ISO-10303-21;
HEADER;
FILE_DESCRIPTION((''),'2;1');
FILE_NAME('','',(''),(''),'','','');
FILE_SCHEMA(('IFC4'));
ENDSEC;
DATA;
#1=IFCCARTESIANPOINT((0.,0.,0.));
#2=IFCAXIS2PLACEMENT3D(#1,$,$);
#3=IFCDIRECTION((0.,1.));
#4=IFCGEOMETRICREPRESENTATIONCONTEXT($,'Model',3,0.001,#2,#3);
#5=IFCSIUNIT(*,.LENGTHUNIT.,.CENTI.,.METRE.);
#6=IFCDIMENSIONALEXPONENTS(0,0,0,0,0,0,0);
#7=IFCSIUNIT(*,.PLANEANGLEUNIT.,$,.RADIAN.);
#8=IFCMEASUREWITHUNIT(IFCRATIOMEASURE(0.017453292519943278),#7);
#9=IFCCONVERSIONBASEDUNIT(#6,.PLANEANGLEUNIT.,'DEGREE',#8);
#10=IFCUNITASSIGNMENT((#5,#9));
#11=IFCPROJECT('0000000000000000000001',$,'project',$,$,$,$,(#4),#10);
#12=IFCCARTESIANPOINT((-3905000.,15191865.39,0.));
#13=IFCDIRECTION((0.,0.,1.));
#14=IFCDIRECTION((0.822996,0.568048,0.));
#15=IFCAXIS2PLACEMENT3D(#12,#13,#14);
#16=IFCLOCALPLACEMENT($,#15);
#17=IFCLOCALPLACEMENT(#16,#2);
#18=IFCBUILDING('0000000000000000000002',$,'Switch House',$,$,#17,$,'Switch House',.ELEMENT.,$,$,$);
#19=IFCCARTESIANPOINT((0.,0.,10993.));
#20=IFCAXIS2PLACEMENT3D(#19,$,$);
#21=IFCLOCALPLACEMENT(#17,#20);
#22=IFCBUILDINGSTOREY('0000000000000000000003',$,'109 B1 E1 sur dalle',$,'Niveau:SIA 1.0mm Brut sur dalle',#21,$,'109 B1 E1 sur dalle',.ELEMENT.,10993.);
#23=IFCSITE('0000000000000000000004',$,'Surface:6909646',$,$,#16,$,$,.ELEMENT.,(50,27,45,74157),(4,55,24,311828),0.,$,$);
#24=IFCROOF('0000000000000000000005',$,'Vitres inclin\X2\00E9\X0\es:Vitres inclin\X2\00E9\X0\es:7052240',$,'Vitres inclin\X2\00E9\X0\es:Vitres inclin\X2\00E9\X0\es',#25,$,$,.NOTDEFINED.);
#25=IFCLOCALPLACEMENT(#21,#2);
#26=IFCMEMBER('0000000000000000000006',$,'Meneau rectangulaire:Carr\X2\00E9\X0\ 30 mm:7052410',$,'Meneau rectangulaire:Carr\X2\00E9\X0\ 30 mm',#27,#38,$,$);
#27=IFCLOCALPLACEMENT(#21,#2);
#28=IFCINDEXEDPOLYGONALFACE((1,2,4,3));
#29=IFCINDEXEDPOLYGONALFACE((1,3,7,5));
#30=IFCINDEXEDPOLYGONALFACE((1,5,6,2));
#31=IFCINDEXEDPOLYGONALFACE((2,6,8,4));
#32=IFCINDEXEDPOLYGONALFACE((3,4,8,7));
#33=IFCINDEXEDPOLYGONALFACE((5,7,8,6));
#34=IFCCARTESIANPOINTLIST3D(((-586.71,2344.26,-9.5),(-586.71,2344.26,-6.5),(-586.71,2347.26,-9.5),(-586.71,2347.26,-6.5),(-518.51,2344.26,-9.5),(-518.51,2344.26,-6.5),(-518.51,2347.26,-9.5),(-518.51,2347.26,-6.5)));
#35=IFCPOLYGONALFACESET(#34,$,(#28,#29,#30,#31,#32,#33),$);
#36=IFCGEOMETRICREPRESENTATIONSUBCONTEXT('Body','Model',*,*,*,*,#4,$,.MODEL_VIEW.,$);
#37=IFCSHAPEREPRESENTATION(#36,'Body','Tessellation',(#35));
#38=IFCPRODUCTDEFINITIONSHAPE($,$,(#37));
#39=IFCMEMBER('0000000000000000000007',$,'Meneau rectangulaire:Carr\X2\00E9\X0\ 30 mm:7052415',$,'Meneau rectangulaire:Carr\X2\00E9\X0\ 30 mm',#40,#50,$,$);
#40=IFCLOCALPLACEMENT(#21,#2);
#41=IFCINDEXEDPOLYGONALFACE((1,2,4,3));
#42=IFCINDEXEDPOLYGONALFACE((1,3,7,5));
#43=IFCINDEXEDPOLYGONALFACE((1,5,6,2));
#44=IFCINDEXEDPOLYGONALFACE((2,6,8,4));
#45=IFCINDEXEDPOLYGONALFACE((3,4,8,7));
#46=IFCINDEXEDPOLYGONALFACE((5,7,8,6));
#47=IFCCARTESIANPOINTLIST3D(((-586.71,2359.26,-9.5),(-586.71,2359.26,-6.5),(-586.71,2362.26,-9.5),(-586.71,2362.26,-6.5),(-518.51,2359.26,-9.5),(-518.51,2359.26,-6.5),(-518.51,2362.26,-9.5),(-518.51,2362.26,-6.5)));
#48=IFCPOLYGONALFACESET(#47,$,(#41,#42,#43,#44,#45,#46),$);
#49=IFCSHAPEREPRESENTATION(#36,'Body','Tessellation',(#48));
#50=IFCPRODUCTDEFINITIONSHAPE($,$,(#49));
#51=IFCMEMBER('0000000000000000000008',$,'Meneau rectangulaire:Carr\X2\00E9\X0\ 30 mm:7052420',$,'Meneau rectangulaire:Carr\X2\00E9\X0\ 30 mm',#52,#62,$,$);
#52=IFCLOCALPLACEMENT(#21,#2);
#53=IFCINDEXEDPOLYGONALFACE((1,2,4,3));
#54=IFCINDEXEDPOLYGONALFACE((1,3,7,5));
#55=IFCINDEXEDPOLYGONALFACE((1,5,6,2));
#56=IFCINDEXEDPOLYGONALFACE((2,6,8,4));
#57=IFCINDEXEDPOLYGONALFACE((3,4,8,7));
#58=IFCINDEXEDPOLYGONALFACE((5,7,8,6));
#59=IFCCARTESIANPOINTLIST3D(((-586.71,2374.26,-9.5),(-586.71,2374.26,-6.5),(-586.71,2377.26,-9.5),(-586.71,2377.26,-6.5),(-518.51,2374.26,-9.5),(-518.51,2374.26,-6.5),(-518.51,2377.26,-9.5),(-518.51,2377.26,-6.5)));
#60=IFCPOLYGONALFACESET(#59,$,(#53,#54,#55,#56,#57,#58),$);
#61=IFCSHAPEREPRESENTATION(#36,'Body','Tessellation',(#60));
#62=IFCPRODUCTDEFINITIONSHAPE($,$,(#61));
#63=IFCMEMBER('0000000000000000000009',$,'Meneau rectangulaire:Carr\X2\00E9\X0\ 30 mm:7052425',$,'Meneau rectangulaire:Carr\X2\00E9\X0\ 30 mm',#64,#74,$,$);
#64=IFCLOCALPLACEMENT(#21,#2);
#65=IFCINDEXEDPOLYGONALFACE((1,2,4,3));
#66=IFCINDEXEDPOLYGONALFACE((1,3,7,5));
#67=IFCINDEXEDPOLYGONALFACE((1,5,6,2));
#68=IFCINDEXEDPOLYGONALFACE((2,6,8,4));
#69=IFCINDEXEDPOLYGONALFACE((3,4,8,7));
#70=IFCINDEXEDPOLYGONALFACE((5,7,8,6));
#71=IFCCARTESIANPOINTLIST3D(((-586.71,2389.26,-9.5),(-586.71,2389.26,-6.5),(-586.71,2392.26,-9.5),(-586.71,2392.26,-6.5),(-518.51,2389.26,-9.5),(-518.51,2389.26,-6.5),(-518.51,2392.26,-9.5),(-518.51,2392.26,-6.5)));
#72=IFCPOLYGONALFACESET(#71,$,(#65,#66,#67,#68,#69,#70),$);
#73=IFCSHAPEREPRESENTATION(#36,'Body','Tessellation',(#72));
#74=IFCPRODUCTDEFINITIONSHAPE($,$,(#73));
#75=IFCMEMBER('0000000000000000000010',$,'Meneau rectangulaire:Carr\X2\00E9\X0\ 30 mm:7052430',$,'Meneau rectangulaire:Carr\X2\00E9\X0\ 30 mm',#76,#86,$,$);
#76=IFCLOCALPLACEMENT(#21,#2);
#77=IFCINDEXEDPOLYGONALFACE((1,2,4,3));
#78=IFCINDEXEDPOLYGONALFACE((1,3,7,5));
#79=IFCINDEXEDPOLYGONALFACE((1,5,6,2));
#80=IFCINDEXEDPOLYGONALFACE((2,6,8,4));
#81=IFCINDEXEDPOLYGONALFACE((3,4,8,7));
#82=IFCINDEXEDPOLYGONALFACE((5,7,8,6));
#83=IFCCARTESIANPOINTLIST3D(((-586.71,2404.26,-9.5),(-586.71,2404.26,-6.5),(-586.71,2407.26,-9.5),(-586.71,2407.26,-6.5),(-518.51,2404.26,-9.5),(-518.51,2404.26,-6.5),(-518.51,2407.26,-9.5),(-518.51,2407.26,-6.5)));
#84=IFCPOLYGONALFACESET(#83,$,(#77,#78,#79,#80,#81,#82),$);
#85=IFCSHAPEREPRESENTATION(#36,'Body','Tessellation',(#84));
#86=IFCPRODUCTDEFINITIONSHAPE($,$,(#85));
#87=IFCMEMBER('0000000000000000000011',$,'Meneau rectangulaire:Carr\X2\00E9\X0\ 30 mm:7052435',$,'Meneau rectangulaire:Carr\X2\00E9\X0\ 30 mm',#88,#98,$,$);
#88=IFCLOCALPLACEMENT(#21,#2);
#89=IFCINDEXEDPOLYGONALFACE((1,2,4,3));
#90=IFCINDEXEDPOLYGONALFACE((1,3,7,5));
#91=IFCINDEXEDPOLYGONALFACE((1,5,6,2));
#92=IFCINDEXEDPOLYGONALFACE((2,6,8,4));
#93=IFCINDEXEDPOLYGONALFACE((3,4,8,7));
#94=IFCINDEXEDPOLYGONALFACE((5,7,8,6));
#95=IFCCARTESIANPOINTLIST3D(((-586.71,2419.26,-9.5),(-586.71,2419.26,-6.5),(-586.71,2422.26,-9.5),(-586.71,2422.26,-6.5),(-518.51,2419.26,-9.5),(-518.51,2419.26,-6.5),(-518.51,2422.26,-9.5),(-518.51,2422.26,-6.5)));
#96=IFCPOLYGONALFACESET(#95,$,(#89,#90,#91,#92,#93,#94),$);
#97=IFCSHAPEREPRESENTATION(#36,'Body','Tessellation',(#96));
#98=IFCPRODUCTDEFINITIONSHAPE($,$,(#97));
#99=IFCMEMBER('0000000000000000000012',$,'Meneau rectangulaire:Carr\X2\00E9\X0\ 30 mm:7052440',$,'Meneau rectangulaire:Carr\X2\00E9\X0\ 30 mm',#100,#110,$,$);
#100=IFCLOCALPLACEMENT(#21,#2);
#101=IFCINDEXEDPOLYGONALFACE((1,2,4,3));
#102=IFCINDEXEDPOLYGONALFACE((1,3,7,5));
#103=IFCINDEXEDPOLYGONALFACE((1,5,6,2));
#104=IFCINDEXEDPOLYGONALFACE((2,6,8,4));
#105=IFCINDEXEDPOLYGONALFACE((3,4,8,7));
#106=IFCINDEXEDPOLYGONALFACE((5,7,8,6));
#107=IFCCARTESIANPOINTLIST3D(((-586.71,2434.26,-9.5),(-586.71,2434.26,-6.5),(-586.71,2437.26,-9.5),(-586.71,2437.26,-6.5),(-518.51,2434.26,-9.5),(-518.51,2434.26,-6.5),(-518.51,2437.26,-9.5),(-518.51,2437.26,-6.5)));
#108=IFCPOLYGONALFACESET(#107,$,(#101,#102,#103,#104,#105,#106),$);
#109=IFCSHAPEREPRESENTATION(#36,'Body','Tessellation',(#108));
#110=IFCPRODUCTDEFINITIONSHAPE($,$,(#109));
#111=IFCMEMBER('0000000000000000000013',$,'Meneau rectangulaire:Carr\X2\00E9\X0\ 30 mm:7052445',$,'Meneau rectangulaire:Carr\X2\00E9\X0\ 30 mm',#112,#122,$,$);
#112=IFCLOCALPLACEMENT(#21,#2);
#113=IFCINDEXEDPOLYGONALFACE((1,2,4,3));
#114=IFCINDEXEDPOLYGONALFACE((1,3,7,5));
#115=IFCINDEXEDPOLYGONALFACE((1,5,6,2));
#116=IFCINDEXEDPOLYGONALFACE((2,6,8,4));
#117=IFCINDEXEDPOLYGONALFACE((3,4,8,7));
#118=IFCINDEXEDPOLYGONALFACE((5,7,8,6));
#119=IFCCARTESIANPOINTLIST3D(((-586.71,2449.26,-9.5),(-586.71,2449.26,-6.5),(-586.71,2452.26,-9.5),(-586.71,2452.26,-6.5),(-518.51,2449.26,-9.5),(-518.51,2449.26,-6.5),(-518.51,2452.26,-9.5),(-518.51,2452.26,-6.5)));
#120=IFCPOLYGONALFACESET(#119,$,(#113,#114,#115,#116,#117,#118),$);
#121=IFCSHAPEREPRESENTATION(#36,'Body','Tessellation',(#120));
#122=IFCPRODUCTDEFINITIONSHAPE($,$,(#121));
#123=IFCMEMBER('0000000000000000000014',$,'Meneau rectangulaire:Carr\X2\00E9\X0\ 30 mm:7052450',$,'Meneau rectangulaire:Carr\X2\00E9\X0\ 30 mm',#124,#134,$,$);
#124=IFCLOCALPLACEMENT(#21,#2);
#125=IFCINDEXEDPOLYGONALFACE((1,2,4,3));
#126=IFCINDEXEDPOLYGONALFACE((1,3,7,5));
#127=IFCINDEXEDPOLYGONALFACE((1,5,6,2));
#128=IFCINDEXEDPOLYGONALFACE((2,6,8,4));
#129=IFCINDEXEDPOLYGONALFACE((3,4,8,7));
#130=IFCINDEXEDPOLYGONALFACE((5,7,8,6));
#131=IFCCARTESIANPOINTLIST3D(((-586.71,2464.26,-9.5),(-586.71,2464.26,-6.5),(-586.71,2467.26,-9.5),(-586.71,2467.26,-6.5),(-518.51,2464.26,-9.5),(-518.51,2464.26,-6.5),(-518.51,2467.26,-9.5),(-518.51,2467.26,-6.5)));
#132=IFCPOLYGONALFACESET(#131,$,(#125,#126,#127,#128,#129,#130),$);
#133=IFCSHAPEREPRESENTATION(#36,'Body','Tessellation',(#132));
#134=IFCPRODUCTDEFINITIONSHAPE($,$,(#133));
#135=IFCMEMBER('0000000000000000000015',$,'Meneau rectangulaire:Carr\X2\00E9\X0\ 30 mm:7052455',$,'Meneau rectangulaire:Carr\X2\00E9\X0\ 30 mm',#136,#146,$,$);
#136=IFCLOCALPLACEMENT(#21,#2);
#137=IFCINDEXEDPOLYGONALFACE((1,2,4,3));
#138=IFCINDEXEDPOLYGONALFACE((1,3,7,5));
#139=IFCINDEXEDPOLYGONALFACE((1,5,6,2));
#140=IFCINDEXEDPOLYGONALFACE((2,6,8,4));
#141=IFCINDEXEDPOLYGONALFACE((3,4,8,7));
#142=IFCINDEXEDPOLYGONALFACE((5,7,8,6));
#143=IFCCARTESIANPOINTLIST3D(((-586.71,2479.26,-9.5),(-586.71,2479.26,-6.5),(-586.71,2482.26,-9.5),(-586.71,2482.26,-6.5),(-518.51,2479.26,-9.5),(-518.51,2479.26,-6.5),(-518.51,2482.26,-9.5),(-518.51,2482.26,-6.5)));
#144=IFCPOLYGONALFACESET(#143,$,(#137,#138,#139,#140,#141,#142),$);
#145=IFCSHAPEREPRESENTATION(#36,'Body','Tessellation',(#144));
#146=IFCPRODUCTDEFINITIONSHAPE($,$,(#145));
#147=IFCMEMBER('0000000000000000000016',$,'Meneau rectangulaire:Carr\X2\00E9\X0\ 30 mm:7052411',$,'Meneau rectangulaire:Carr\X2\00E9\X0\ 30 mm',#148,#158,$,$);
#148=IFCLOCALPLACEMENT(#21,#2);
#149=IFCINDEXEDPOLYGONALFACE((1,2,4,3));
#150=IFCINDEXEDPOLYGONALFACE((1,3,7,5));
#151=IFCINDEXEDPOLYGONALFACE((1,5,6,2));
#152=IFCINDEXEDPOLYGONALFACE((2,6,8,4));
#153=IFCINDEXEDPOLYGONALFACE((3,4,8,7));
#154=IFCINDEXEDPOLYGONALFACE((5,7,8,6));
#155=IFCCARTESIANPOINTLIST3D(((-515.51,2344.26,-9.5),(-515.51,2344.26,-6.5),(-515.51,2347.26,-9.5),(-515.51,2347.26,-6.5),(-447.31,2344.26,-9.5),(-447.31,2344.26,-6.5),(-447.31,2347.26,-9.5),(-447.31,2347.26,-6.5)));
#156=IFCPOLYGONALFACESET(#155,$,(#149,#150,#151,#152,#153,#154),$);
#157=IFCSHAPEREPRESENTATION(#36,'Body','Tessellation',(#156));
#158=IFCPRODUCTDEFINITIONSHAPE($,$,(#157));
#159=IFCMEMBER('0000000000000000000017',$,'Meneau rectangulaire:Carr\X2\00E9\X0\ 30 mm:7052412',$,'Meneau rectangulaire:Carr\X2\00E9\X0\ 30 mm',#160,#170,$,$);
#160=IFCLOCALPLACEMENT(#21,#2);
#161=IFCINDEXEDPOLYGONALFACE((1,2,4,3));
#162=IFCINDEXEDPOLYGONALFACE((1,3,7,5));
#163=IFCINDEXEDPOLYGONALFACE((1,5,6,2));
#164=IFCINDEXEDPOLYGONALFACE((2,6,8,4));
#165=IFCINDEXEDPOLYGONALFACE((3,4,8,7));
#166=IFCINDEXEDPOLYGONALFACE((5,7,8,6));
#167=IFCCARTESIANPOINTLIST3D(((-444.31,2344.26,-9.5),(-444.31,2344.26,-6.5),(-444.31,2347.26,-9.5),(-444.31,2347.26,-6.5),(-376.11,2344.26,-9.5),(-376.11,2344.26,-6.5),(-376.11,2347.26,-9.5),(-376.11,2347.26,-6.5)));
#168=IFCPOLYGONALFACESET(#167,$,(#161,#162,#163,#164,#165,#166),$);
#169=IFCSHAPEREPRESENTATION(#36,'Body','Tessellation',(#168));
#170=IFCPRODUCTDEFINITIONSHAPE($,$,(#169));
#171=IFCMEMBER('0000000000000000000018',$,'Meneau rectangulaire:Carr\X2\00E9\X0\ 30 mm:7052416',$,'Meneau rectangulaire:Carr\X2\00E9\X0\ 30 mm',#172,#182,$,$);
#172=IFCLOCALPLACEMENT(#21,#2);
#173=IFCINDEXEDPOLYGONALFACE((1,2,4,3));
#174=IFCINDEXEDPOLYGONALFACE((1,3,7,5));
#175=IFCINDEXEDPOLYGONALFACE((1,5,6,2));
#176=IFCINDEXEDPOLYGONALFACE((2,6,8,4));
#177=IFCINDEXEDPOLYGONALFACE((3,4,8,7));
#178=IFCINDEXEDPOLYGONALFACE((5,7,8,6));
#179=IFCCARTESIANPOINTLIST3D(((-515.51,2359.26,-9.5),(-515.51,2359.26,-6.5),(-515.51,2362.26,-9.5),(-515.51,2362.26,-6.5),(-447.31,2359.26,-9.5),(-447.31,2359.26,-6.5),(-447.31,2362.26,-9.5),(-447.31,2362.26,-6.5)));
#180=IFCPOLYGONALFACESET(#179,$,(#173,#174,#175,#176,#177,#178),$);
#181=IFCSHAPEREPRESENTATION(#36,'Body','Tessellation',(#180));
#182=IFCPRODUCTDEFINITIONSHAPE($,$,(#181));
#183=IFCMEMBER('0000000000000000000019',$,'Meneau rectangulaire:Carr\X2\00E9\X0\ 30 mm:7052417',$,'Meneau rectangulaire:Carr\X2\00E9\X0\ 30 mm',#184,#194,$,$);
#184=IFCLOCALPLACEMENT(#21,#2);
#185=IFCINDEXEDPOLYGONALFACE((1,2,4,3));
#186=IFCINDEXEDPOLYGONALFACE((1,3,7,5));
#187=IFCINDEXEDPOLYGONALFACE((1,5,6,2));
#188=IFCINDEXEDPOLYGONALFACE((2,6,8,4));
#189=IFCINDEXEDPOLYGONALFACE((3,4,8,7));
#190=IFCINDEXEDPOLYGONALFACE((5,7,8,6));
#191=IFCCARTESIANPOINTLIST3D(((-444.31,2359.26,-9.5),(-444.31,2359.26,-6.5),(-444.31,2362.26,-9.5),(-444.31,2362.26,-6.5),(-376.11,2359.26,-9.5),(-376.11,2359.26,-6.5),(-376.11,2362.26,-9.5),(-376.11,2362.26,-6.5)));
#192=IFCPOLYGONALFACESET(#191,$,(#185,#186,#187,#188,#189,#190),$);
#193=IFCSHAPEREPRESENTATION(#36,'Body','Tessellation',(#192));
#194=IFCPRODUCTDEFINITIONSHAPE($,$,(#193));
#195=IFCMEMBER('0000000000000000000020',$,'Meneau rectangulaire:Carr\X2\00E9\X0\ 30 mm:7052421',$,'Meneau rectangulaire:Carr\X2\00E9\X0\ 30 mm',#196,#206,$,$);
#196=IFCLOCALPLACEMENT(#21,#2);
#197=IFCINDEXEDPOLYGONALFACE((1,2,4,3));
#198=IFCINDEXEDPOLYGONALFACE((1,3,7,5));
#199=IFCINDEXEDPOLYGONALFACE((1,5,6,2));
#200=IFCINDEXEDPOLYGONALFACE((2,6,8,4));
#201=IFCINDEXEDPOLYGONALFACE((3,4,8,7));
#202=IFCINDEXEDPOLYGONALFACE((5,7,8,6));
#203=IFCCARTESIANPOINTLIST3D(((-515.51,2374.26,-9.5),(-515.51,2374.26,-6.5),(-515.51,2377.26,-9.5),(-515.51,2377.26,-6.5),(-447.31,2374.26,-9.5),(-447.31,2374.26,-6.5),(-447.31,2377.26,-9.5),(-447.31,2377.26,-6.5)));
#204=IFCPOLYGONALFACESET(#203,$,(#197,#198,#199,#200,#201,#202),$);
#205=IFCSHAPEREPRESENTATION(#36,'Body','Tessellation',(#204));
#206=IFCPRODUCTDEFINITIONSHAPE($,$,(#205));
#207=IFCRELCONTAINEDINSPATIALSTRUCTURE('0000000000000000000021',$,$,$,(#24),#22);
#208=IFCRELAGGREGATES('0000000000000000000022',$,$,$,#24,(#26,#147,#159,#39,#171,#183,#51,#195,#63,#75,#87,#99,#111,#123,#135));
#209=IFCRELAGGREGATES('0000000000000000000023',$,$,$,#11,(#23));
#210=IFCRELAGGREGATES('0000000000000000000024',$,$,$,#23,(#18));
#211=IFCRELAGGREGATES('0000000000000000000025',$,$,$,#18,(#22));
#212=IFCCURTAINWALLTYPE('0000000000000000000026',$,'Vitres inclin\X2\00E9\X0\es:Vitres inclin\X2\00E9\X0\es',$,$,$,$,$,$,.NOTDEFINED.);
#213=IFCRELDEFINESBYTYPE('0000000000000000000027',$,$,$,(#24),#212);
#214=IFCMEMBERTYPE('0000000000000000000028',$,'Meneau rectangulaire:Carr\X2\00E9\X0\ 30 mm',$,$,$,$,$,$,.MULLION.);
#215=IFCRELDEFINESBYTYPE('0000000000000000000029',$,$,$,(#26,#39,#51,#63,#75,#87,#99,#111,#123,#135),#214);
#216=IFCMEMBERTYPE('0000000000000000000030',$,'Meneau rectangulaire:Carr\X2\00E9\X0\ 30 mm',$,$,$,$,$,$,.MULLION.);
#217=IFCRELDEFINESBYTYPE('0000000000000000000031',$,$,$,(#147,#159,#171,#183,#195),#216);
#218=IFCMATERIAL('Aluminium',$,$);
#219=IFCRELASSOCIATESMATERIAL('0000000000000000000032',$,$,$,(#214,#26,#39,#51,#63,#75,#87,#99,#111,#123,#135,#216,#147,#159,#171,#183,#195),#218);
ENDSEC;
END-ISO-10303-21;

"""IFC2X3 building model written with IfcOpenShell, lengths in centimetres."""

from ifc_helpers import new_model, entity, si_unit, converted_unit, direction, frame, origin, origin_2d_with_axis, place, context, subcontext, project, spatial, rectangle, extrude, source, transform, mapped, material, type_object, type_shapes, element, aggregate, save


model = new_model("IFC2X3")

# Units and contexts
model_context = context("Model", 3, precision=0.001, world=origin(), true_north=direction((0.0, 1.0)))
body_context = subcontext(model_context, "Body", "Model", "MODEL_VIEW")
ifc_project = project(units=[si_unit("LENGTHUNIT", "METRE", prefix="CENTI"), converted_unit("PLANEANGLEUNIT", "DEGREE", entity("IfcRatioMeasure", 0.017453292519943278), si_unit("PLANEANGLEUNIT", "RADIAN"), dimensions=[0, 0, 0, 0, 0, 0, 0])], contexts=[model_context])

# Site, building, storey
site_placement = place(None, frame((-3905000.0, 15191865.39, 0.0), z_axis=(0.0, 0.0, 1.0), x_axis=(0.822996, 0.568048, 0.0)))
site = spatial("IfcSite", under=ifc_project, at=site_placement, Name="Surface:6909646", CompositionType="ELEMENT", RefLatitude=(50, 27, 45, 74157), RefLongitude=(4, 55, 24, 311828), RefElevation=0.0)
building_placement = place(site_placement, origin())
building = spatial("IfcBuilding", under=site, at=building_placement, Name="Switch House", LongName="Switch House", CompositionType="ELEMENT")
storey_placement = place(building_placement, frame((0.0, 0.0, 10993.0)))
storey = spatial("IfcBuildingStorey", under=building, at=storey_placement, Name="109 B1 E1 sur dalle", ObjectType="Niveau:SIA 1.0mm Brut sur dalle", LongName="109 B1 E1 sur dalle", CompositionType="ELEMENT", Elevation=10993.0)

# Roof, members
curtain_wall_type = type_object("IfcCurtainWallType", Name="Vitres inclinées:Vitres inclinées", PredefinedType="NOTDEFINED")
roof_1_placement = place(storey_placement, frame((0.0, 0.0, -10993.0)))
roof_1 = element("IfcRoof", 1, at=roof_1_placement, inside=storey, type_object=curtain_wall_type, Name="Vitres inclinées:Vitres inclinées:7052240", ObjectType="Vitres inclinées:Vitres inclinées", ShapeType="NOTDEFINED")
ifc_material_1 = material(Name="Aluminium")
member_type_1 = type_object("IfcMemberType", Name="Meneau rectangulaire:Carré 30 mm", PredefinedType="MULLION", material=ifc_material_1)
shared_shape_1 = source(origin(), body_context, "Body", "SweptSolid", [
    extrude(rectangle(XDim=3.0, YDim=3.0, at=origin_2d_with_axis()), frame((0.0, 0.0, -68.2), z_axis=(0.0, 0.0, 1.0), x_axis=(0.0, -1.0, 0.0)), (0.0, 0.0, 1.0), 68.2),
])
type_shapes(member_type_1, [shared_shape_1])
member_1_placement = place(roof_1_placement, frame((-586.71, 2345.76, 10985.0), z_axis=(-1.0, 0.0, 0.0), x_axis=(0.0, 1.0, 0.0)))
member_1 = element("IfcMember", 2, at=member_1_placement, type_object=member_type_1, material=ifc_material_1, Name="Meneau rectangulaire:Carré 30 mm:7052410", ObjectType="Meneau rectangulaire:Carré 30 mm", context=body_context, shape_type="MappedRepresentation", body=[
    mapped(shared_shape_1, transform((0.0, 0.0, 0.0), scale=1.0)),
])
member_2_placement = place(roof_1_placement, frame((-586.71, 2360.76, 10985.0), z_axis=(-1.0, 0.0, 0.0), x_axis=(0.0, 1.0, 0.0)))
member_2 = element("IfcMember", 3, at=member_2_placement, type_object=member_type_1, material=ifc_material_1, Name="Meneau rectangulaire:Carré 30 mm:7052415", ObjectType="Meneau rectangulaire:Carré 30 mm", context=body_context, shape_type="MappedRepresentation", body=[
    mapped(shared_shape_1, transform((0.0, 0.0, 0.0), scale=1.0)),
])
member_3_placement = place(roof_1_placement, frame((-586.71, 2375.76, 10985.0), z_axis=(-1.0, 0.0, 0.0), x_axis=(0.0, 1.0, 0.0)))
member_3 = element("IfcMember", 4, at=member_3_placement, type_object=member_type_1, material=ifc_material_1, Name="Meneau rectangulaire:Carré 30 mm:7052420", ObjectType="Meneau rectangulaire:Carré 30 mm", context=body_context, shape_type="MappedRepresentation", body=[
    mapped(shared_shape_1, transform((0.0, 0.0, 0.0), scale=1.0)),
])
member_4_placement = place(roof_1_placement, frame((-586.71, 2390.76, 10985.0), z_axis=(-1.0, 0.0, 0.0), x_axis=(0.0, 1.0, 0.0)))
member_4 = element("IfcMember", 5, at=member_4_placement, type_object=member_type_1, material=ifc_material_1, Name="Meneau rectangulaire:Carré 30 mm:7052425", ObjectType="Meneau rectangulaire:Carré 30 mm", context=body_context, shape_type="MappedRepresentation", body=[
    mapped(shared_shape_1, transform((0.0, 0.0, 0.0), scale=1.0)),
])
member_5_placement = place(roof_1_placement, frame((-586.71, 2405.76, 10985.0), z_axis=(-1.0, 0.0, 0.0), x_axis=(0.0, 1.0, 0.0)))
member_5 = element("IfcMember", 6, at=member_5_placement, type_object=member_type_1, material=ifc_material_1, Name="Meneau rectangulaire:Carré 30 mm:7052430", ObjectType="Meneau rectangulaire:Carré 30 mm", context=body_context, shape_type="MappedRepresentation", body=[
    mapped(shared_shape_1, transform((0.0, 0.0, 0.0), scale=1.0)),
])
member_6_placement = place(roof_1_placement, frame((-586.71, 2420.76, 10985.0), z_axis=(-1.0, 0.0, 0.0), x_axis=(0.0, 1.0, 0.0)))
member_6 = element("IfcMember", 7, at=member_6_placement, type_object=member_type_1, material=ifc_material_1, Name="Meneau rectangulaire:Carré 30 mm:7052435", ObjectType="Meneau rectangulaire:Carré 30 mm", context=body_context, shape_type="MappedRepresentation", body=[
    mapped(shared_shape_1, transform((0.0, 0.0, 0.0), scale=1.0)),
])
member_7_placement = place(roof_1_placement, frame((-586.71, 2435.76, 10985.0), z_axis=(-1.0, 0.0, 0.0), x_axis=(0.0, 1.0, 0.0)))
member_7 = element("IfcMember", 8, at=member_7_placement, type_object=member_type_1, material=ifc_material_1, Name="Meneau rectangulaire:Carré 30 mm:7052440", ObjectType="Meneau rectangulaire:Carré 30 mm", context=body_context, shape_type="MappedRepresentation", body=[
    mapped(shared_shape_1, transform((0.0, 0.0, 0.0), scale=1.0)),
])
member_8_placement = place(roof_1_placement, frame((-586.71, 2450.76, 10985.0), z_axis=(-1.0, 0.0, 0.0), x_axis=(0.0, 1.0, 0.0)))
member_8 = element("IfcMember", 9, at=member_8_placement, type_object=member_type_1, material=ifc_material_1, Name="Meneau rectangulaire:Carré 30 mm:7052445", ObjectType="Meneau rectangulaire:Carré 30 mm", context=body_context, shape_type="MappedRepresentation", body=[
    mapped(shared_shape_1, transform((0.0, 0.0, 0.0), scale=1.0)),
])
member_9_placement = place(roof_1_placement, frame((-586.71, 2465.76, 10985.0), z_axis=(-1.0, 0.0, 0.0), x_axis=(0.0, 1.0, 0.0)))
member_9 = element("IfcMember", 10, at=member_9_placement, type_object=member_type_1, material=ifc_material_1, Name="Meneau rectangulaire:Carré 30 mm:7052450", ObjectType="Meneau rectangulaire:Carré 30 mm", context=body_context, shape_type="MappedRepresentation", body=[
    mapped(shared_shape_1, transform((0.0, 0.0, 0.0), scale=1.0)),
])
member_10_placement = place(roof_1_placement, frame((-586.71, 2480.76, 10985.0), z_axis=(-1.0, 0.0, 0.0), x_axis=(0.0, 1.0, 0.0)))
member_10 = element("IfcMember", 11, at=member_10_placement, type_object=member_type_1, material=ifc_material_1, Name="Meneau rectangulaire:Carré 30 mm:7052455", ObjectType="Meneau rectangulaire:Carré 30 mm", context=body_context, shape_type="MappedRepresentation", body=[
    mapped(shared_shape_1, transform((0.0, 0.0, 0.0), scale=1.0)),
])
member_type_2 = type_object("IfcMemberType", Name="Meneau rectangulaire:Carré 30 mm", PredefinedType="MULLION", material=ifc_material_1)
shared_shape_2 = source(origin(), body_context, "Body", "SweptSolid", [
    extrude(rectangle(XDim=3.0, YDim=3.0, at=origin_2d_with_axis()), frame((0.0, 0.0, -68.2), z_axis=(0.0, 0.0, 1.0), x_axis=(0.0, -1.0, 0.0)), (0.0, 0.0, 1.0), 68.2),
])
type_shapes(member_type_2, [shared_shape_2])
member_11_placement = place(roof_1_placement, frame((-515.51, 2345.76, 10985.0), z_axis=(-1.0, 0.0, 0.0), x_axis=(0.0, 1.0, 0.0)))
member_11 = element("IfcMember", 12, at=member_11_placement, type_object=member_type_2, material=ifc_material_1, Name="Meneau rectangulaire:Carré 30 mm:7052411", ObjectType="Meneau rectangulaire:Carré 30 mm", context=body_context, shape_type="MappedRepresentation", body=[
    mapped(shared_shape_2, transform((0.0, 0.0, 0.0), scale=1.0)),
])
member_12_placement = place(roof_1_placement, frame((-444.31, 2345.76, 10985.0), z_axis=(-1.0, 0.0, 0.0), x_axis=(0.0, 1.0, 0.0)))
member_12 = element("IfcMember", 13, at=member_12_placement, type_object=member_type_2, material=ifc_material_1, Name="Meneau rectangulaire:Carré 30 mm:7052412", ObjectType="Meneau rectangulaire:Carré 30 mm", context=body_context, shape_type="MappedRepresentation", body=[
    mapped(shared_shape_2, transform((0.0, 0.0, 0.0), scale=1.0)),
])
member_13_placement = place(roof_1_placement, frame((-515.51, 2360.76, 10985.0), z_axis=(-1.0, 0.0, 0.0), x_axis=(0.0, 1.0, 0.0)))
member_13 = element("IfcMember", 14, at=member_13_placement, type_object=member_type_2, material=ifc_material_1, Name="Meneau rectangulaire:Carré 30 mm:7052416", ObjectType="Meneau rectangulaire:Carré 30 mm", context=body_context, shape_type="MappedRepresentation", body=[
    mapped(shared_shape_2, transform((0.0, 0.0, 0.0), scale=1.0)),
])
member_14_placement = place(roof_1_placement, frame((-444.31, 2360.76, 10985.0), z_axis=(-1.0, 0.0, 0.0), x_axis=(0.0, 1.0, 0.0)))
member_14 = element("IfcMember", 15, at=member_14_placement, type_object=member_type_2, material=ifc_material_1, Name="Meneau rectangulaire:Carré 30 mm:7052417", ObjectType="Meneau rectangulaire:Carré 30 mm", context=body_context, shape_type="MappedRepresentation", body=[
    mapped(shared_shape_2, transform((0.0, 0.0, 0.0), scale=1.0)),
])
member_15_placement = place(roof_1_placement, frame((-515.51, 2375.76, 10985.0), z_axis=(-1.0, 0.0, 0.0), x_axis=(0.0, 1.0, 0.0)))
member_15 = element("IfcMember", 16, at=member_15_placement, type_object=member_type_2, material=ifc_material_1, Name="Meneau rectangulaire:Carré 30 mm:7052421", ObjectType="Meneau rectangulaire:Carré 30 mm", context=body_context, shape_type="MappedRepresentation", body=[
    mapped(shared_shape_2, transform((0.0, 0.0, 0.0), scale=1.0)),
])
aggregate(roof_1, [member_1, member_11, member_12, member_2, member_13, member_14, member_3, member_15, member_4, member_5, member_6, member_7, member_8, member_9, member_10])

save(model, "model.ifc")
